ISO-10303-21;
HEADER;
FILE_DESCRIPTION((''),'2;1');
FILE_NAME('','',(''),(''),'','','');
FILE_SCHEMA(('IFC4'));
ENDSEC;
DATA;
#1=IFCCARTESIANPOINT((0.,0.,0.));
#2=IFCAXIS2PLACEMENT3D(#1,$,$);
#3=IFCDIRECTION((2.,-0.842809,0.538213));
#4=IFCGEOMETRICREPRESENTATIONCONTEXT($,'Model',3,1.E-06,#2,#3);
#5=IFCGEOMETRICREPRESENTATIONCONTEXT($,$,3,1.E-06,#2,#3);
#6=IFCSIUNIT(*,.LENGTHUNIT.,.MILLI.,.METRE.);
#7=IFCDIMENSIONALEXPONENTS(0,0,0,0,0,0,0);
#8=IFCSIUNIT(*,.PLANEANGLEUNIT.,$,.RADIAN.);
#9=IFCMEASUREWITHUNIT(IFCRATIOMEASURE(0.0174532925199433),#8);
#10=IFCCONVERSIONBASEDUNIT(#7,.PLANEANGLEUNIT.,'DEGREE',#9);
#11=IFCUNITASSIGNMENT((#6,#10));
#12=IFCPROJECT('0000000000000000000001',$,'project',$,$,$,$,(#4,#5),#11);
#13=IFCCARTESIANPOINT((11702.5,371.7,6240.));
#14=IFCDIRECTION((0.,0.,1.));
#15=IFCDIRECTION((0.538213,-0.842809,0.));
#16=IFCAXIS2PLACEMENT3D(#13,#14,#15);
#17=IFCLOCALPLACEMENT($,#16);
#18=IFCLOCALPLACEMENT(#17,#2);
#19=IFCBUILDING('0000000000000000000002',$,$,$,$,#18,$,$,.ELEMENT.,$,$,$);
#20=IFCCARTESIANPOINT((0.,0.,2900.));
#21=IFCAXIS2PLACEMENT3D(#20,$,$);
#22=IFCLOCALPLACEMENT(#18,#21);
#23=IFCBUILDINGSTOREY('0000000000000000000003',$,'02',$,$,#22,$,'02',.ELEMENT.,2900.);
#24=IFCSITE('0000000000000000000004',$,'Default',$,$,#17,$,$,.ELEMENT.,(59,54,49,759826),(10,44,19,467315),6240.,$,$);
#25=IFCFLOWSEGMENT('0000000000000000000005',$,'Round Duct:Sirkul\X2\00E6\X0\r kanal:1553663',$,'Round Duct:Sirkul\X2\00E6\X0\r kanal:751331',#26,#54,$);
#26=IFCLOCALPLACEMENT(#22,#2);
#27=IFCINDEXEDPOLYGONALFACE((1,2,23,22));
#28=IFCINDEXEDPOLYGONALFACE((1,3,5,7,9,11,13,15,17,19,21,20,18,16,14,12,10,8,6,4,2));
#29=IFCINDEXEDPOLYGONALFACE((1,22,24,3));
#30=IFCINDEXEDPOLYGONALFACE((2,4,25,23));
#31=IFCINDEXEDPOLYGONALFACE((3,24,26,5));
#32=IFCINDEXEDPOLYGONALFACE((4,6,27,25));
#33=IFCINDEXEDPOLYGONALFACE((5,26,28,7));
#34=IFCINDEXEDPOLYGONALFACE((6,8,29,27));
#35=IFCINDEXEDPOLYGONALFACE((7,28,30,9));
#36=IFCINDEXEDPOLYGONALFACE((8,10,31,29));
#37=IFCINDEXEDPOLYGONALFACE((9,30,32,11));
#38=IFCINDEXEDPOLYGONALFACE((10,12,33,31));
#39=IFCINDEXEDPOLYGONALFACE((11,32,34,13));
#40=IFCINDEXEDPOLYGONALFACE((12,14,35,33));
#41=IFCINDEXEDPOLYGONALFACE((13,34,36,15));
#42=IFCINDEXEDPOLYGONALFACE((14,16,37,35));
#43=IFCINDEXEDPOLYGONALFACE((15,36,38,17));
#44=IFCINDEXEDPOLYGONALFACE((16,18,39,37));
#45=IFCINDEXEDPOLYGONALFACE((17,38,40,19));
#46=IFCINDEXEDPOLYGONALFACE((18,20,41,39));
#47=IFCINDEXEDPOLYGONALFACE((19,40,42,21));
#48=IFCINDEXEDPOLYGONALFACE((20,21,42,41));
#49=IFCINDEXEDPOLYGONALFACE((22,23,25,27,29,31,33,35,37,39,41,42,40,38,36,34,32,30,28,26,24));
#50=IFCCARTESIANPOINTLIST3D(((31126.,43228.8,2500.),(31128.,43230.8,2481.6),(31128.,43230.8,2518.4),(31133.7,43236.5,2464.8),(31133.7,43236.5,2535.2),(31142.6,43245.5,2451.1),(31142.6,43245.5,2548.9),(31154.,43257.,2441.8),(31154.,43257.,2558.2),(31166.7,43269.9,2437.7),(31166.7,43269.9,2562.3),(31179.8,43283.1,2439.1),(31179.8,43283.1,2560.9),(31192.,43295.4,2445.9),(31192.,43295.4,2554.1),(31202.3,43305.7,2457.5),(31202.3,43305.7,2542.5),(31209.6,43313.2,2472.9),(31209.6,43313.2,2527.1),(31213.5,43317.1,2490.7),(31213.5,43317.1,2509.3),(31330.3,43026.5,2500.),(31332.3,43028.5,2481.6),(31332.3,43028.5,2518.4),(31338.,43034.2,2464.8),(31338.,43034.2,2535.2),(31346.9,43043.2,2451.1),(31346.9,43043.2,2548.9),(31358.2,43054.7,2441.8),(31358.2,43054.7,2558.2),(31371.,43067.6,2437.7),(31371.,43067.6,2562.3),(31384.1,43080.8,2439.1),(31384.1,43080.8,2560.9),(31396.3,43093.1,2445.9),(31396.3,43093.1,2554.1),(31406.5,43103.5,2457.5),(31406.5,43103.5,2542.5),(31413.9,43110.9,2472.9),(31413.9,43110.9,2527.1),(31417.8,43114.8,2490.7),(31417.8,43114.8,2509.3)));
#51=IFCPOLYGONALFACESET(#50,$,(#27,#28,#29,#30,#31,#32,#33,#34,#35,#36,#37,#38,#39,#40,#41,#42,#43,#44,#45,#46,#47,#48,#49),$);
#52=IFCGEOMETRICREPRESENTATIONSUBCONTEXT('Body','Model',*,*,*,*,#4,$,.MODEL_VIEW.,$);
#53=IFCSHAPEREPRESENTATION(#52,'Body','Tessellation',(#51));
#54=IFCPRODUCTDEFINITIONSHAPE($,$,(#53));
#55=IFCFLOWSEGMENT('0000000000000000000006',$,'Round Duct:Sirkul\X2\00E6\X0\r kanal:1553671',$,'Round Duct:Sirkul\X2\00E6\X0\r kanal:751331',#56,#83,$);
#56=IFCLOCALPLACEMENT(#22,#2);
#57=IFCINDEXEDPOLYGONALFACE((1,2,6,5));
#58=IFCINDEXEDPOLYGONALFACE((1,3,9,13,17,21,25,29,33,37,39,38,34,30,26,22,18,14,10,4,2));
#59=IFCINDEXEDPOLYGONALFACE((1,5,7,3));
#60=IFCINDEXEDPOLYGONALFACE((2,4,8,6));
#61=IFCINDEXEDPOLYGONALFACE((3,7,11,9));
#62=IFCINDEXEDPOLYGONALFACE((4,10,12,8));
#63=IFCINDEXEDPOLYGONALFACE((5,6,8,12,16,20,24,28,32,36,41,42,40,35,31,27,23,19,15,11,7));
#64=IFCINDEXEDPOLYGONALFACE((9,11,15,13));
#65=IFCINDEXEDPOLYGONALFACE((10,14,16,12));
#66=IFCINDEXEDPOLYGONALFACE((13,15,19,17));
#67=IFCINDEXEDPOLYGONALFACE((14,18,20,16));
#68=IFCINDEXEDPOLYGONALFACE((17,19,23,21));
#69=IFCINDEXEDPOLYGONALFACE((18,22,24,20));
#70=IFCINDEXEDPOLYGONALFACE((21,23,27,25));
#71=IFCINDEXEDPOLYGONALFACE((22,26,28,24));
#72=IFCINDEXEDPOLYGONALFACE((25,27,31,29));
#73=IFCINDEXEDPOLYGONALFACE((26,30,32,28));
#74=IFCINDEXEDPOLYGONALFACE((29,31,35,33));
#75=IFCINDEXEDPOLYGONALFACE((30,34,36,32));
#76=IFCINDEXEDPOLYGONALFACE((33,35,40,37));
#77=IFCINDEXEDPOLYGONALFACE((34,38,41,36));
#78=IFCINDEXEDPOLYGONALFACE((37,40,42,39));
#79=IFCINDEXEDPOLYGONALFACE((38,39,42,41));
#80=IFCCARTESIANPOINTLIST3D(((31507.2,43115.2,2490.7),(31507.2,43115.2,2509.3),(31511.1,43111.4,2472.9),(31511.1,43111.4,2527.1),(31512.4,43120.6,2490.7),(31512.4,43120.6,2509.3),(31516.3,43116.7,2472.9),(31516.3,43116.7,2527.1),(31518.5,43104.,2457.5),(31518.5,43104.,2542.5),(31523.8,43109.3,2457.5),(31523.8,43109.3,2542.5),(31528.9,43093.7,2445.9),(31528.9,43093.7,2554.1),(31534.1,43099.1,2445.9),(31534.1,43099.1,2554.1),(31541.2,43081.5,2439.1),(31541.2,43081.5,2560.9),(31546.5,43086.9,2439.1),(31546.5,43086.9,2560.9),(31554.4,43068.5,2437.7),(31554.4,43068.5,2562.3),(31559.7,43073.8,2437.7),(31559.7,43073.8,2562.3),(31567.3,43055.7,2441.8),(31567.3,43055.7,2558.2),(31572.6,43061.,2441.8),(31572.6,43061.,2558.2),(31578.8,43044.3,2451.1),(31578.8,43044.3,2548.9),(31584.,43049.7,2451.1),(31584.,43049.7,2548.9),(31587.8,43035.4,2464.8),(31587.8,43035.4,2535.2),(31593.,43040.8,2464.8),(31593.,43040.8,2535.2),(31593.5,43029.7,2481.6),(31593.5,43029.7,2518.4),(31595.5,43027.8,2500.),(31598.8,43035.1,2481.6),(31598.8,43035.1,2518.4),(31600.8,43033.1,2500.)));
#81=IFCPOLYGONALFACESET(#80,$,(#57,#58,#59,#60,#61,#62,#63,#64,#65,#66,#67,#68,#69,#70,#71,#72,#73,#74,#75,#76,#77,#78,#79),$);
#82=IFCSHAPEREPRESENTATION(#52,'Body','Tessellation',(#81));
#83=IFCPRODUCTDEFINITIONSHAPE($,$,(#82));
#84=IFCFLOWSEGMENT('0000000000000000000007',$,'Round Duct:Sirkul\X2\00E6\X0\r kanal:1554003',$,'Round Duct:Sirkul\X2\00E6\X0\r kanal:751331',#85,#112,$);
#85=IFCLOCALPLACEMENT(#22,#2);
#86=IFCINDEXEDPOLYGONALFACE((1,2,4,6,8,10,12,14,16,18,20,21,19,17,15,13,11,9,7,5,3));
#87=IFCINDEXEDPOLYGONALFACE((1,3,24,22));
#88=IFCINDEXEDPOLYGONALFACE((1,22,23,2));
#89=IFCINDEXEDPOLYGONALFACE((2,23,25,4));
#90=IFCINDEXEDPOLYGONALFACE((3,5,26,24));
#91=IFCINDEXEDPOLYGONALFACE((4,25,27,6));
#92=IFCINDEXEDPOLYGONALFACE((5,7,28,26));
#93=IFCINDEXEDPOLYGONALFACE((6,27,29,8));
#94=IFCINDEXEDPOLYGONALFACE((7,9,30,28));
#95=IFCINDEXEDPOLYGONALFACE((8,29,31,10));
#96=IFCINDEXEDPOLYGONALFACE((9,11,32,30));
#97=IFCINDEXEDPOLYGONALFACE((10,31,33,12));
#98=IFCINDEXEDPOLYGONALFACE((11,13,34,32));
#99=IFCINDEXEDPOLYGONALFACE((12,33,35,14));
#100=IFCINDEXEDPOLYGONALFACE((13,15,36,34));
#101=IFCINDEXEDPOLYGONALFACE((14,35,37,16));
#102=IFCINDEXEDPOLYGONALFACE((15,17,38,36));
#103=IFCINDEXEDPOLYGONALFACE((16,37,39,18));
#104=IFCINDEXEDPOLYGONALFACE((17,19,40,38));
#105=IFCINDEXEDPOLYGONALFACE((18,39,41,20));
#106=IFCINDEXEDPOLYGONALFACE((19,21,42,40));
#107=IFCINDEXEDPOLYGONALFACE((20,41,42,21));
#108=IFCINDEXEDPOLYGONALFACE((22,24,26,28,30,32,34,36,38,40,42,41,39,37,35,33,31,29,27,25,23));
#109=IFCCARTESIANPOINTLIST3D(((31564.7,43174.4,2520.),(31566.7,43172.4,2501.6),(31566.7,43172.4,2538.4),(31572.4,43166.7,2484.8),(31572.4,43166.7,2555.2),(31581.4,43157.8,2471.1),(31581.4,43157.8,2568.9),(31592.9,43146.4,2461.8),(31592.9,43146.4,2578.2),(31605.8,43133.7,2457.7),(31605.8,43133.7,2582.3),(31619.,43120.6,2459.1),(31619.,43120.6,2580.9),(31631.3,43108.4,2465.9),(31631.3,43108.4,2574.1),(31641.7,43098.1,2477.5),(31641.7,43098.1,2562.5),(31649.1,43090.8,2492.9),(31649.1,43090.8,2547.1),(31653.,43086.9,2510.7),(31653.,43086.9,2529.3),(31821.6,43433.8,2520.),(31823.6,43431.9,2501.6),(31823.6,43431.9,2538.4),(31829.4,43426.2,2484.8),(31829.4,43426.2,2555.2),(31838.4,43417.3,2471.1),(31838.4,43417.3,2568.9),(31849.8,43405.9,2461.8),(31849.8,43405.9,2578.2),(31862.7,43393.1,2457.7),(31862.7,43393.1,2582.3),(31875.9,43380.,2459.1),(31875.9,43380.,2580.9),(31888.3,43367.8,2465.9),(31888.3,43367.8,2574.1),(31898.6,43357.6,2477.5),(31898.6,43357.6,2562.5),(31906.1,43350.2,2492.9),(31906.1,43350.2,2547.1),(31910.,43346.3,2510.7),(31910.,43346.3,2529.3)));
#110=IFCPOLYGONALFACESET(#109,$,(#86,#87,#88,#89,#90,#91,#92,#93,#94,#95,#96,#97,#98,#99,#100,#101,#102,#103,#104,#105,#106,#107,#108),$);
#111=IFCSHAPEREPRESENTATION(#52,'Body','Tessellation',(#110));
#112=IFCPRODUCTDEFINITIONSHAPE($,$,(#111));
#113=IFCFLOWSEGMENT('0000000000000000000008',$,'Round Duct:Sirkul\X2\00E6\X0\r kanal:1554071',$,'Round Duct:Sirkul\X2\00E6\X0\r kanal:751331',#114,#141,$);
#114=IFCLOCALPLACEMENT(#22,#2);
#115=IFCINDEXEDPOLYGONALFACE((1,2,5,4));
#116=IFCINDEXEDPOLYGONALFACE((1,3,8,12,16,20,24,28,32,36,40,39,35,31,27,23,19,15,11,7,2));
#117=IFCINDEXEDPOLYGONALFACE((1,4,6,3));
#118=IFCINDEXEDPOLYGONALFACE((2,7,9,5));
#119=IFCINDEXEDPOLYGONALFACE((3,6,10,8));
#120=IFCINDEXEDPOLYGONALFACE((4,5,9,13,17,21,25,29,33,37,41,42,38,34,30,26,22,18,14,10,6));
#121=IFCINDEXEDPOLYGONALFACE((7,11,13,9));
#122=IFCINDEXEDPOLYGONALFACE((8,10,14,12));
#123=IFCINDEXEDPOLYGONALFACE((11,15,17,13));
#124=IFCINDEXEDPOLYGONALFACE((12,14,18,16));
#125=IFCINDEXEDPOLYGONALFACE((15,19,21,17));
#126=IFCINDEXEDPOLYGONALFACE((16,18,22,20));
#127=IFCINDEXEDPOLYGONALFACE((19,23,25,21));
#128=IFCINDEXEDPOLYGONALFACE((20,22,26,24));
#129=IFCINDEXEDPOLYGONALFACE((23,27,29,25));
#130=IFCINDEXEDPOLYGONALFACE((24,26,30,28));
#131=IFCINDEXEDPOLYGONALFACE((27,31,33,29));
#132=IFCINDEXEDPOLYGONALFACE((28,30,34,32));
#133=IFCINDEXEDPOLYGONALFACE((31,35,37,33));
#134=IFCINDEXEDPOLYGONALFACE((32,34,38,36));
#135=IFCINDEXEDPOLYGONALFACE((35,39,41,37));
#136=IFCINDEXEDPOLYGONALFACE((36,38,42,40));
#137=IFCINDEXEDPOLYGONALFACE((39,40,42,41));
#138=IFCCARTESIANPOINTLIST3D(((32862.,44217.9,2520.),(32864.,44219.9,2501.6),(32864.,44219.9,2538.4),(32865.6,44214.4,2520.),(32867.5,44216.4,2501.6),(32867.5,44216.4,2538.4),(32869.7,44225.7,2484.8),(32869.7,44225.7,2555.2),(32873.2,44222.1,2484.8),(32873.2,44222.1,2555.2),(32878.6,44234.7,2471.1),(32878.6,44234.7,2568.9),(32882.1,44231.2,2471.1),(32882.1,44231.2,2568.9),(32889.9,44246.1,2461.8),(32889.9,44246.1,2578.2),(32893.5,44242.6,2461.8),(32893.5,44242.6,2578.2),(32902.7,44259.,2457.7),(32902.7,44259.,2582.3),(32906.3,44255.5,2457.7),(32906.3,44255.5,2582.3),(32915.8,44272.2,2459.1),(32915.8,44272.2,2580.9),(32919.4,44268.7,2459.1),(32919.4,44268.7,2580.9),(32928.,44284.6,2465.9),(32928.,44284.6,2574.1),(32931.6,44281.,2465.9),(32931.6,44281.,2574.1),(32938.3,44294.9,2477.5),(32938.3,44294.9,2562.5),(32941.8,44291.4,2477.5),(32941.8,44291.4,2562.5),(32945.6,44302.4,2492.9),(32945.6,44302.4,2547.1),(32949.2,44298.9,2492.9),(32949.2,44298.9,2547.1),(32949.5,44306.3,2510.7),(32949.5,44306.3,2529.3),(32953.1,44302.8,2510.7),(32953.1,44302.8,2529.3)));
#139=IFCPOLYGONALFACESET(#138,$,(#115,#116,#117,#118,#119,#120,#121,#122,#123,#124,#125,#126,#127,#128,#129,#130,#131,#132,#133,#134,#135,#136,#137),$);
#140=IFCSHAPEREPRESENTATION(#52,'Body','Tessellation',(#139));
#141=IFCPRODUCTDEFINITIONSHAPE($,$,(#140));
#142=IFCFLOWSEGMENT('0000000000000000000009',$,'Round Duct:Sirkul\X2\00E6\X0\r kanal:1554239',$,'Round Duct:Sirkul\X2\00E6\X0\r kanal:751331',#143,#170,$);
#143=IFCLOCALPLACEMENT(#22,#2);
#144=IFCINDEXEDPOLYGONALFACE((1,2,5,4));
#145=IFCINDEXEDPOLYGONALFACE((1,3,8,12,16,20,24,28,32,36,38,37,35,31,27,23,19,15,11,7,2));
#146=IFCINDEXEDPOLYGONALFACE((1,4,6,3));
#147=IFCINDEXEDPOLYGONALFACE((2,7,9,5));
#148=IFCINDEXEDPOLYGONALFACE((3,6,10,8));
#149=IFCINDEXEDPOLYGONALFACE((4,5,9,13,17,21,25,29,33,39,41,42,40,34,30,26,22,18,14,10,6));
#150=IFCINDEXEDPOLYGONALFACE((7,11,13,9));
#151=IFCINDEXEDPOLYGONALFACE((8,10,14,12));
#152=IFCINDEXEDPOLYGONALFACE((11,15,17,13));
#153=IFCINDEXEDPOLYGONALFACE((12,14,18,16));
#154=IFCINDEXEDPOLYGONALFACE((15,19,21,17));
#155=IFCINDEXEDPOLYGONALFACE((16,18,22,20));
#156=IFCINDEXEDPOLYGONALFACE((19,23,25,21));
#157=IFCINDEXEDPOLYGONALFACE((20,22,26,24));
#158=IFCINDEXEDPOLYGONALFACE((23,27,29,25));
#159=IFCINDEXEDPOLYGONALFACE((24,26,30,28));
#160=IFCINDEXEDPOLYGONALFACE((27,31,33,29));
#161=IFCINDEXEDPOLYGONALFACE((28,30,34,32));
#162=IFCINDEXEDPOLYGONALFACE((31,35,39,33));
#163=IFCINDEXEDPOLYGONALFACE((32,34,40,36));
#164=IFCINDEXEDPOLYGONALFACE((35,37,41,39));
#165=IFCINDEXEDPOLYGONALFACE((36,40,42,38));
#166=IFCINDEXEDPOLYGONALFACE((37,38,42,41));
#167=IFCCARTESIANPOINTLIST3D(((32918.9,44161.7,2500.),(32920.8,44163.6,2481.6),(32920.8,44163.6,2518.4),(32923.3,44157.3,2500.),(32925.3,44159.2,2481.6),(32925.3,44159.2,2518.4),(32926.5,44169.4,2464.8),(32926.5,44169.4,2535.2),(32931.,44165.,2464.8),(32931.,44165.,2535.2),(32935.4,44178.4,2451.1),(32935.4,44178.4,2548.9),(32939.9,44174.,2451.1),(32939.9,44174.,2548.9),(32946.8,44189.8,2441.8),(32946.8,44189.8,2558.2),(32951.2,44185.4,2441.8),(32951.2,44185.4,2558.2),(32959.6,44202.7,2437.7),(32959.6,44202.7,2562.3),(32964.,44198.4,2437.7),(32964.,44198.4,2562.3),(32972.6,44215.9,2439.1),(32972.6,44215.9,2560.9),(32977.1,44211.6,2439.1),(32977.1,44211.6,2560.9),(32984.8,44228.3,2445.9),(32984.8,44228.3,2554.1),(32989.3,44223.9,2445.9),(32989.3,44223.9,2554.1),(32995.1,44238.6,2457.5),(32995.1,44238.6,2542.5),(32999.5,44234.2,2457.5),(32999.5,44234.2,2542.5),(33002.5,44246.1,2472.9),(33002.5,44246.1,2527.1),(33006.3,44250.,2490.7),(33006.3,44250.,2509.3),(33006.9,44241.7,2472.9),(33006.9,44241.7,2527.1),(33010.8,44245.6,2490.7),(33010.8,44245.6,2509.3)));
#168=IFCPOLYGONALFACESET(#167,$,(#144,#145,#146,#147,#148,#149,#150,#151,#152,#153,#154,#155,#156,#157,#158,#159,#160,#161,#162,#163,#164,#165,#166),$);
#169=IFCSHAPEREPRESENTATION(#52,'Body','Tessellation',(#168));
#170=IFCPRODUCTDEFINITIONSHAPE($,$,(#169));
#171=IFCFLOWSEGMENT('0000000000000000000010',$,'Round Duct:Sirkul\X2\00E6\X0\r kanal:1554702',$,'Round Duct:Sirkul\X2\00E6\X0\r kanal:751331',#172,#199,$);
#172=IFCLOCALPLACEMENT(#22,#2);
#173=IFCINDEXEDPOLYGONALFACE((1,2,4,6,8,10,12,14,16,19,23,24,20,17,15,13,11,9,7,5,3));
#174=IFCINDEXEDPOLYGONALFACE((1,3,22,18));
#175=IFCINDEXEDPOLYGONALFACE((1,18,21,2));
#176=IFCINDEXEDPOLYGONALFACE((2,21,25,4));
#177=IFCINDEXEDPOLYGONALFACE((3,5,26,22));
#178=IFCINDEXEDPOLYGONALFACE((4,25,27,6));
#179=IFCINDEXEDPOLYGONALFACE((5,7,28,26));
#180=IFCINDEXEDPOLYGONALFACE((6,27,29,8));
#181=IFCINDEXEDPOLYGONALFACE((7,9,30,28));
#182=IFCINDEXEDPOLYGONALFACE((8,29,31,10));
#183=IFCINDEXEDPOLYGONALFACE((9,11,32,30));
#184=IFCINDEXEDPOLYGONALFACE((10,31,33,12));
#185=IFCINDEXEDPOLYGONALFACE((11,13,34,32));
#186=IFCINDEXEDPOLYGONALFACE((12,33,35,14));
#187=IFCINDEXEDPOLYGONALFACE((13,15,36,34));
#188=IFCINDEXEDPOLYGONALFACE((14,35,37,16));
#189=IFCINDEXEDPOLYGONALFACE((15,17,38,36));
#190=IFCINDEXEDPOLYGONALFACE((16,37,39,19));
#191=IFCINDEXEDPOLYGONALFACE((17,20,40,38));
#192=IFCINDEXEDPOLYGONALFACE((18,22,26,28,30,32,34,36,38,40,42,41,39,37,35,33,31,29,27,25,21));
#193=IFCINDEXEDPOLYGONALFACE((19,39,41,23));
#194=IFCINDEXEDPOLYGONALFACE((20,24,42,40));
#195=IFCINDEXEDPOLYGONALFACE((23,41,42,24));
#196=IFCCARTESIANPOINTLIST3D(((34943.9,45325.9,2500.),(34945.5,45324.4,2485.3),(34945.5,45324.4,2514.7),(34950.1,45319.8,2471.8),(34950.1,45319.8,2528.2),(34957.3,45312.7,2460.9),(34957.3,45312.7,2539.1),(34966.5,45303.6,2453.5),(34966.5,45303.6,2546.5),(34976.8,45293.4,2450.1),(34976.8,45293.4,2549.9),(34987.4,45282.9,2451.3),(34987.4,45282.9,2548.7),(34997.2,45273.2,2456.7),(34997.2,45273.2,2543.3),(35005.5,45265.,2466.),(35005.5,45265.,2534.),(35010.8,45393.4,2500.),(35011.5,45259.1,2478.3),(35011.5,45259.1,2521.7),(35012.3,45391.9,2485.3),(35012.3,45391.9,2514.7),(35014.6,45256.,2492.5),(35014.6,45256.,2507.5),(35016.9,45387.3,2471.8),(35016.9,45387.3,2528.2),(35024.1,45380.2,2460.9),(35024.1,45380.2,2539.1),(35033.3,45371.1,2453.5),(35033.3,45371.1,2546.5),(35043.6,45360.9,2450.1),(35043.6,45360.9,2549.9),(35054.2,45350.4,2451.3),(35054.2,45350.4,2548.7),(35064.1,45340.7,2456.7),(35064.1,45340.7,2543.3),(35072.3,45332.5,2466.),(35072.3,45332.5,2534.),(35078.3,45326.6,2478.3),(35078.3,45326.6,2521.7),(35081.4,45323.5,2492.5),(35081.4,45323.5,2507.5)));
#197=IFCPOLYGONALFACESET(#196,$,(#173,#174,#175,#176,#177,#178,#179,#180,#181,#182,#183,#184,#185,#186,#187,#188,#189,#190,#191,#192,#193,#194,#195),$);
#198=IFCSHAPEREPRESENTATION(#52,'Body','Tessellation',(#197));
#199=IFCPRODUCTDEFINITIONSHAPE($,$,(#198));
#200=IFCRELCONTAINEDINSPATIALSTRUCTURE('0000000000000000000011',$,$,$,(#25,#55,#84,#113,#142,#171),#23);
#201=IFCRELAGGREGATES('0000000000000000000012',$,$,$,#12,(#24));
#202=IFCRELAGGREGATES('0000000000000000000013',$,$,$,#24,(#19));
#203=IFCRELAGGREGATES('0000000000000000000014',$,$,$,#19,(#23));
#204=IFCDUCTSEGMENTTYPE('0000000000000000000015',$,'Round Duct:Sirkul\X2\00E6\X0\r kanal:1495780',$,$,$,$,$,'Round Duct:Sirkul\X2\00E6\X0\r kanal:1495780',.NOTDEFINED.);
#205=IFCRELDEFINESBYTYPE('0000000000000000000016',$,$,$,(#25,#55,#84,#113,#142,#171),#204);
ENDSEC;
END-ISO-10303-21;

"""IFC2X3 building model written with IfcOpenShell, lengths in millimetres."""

from ifc_helpers import new_model, entity, si_unit, converted_unit, direction, frame, origin, origin_2d_with_axis, place, context, subcontext, project, spatial, circle, extrude, type_object, element, save


model = new_model("IFC2X3")

# Units and contexts
model_context = context("Model", 3, precision=1e-06, world=origin(), true_north=direction((2.0, -0.842809, 0.538213)))
context_of_model = context(None, 3, precision=1e-06, world=origin(), true_north=direction((2.0, -0.842809, 0.538213)))
body_context = subcontext(model_context, "Body", "Model", "MODEL_VIEW")
ifc_project = project(units=[si_unit("LENGTHUNIT", "METRE", prefix="MILLI"), converted_unit("PLANEANGLEUNIT", "DEGREE", entity("IfcRatioMeasure", 0.0174532925199433), si_unit("PLANEANGLEUNIT", "RADIAN"), dimensions=[0, 0, 0, 0, 0, 0, 0])], contexts=[model_context, context_of_model])

# Site, building, storey
site_placement = place(None, frame((11702.5, 371.7, 6240.0), z_axis=(0.0, 0.0, 1.0), x_axis=(0.538213, -0.842809, 0.0)))
site = spatial("IfcSite", under=ifc_project, at=site_placement, Name="Default", CompositionType="ELEMENT", RefLatitude=(59, 54, 49, 759826), RefLongitude=(10, 44, 19, 467315), RefElevation=6240.0)
building_placement = place(site_placement, origin())
building = spatial("IfcBuilding", under=site, at=building_placement, CompositionType="ELEMENT")
storey_placement = place(building_placement, frame((0.0, 0.0, 2900.0)))
storey = spatial("IfcBuildingStorey", under=building, at=storey_placement, Name="02", LongName="02", CompositionType="ELEMENT", Elevation=2900.0)

# Flow segments
duct_segment_type = type_object("IfcDuctSegmentType", Name="Round Duct:Sirkulær kanal:1495780", ElementType="Round Duct:Sirkulær kanal:1495780", PredefinedType="NOTDEFINED")
flow_segment_1_placement = place(storey_placement, origin())
element("IfcFlowSegment", 1, at=flow_segment_1_placement, inside=storey, type_object=duct_segment_type, Name="Round Duct:Sirkulær kanal:1553663", ObjectType="Round Duct:Sirkulær kanal:751331", context=body_context, shape_type="SweptSolid", body=[
    extrude(circle(Radius=62.5, at=origin_2d_with_axis()), frame((31374.3, 43070.9, 2500.0), z_axis=(-0.710554, 0.703643, 0.0), x_axis=(-0.703643, -0.710554, 0.0)), (0.0, 0.0, 1.0), 287.5),
])
flow_segment_2_placement = place(storey_placement, origin())
element("IfcFlowSegment", 2, at=flow_segment_2_placement, inside=storey, type_object=duct_segment_type, Name="Round Duct:Sirkulær kanal:1553671", ObjectType="Round Duct:Sirkulær kanal:751331", context=body_context, shape_type="SweptSolid", body=[
    extrude(circle(Radius=62.5, at=origin_2d_with_axis()), frame((31551.1, 43071.8, 2500.0), z_axis=(0.703643, 0.710554, 0.0), x_axis=(0.710554, -0.703643, 0.0)), (0.0, 0.0, 1.0), 7.5),
])
flow_segment_3_placement = place(storey_placement, origin())
element("IfcFlowSegment", 3, at=flow_segment_3_placement, inside=storey, type_object=duct_segment_type, Name="Round Duct:Sirkulær kanal:1554003", ObjectType="Round Duct:Sirkulær kanal:751331", context=body_context, shape_type="SweptSolid", body=[
    extrude(circle(Radius=62.5, at=origin_2d_with_axis()), frame((31609.1, 43130.4, 2520.0), z_axis=(0.703643, 0.710554, 0.0), x_axis=(-0.710554, 0.703643, 0.0)), (0.0, 0.0, 1.0), 365.1),
])
flow_segment_4_placement = place(storey_placement, origin())
element("IfcFlowSegment", 4, at=flow_segment_4_placement, inside=storey, type_object=duct_segment_type, Name="Round Duct:Sirkulær kanal:1554071", ObjectType="Round Duct:Sirkulær kanal:751331", context=body_context, shape_type="SweptSolid", body=[
    extrude(circle(Radius=62.5, at=origin_2d_with_axis()), frame((32906.0, 44262.4, 2520.0), z_axis=(0.710554, -0.703643, 0.0), x_axis=(-0.703643, -0.710554, 0.0)), (0.0, 0.0, 1.0), 5.0),
])
flow_segment_5_placement = place(storey_placement, origin())
element("IfcFlowSegment", 5, at=flow_segment_5_placement, inside=storey, type_object=duct_segment_type, Name="Round Duct:Sirkulær kanal:1554239", ObjectType="Round Duct:Sirkulær kanal:751331", context=body_context, shape_type="SweptSolid", body=[
    extrude(circle(Radius=62.5, at=origin_2d_with_axis()), frame((32967.3, 44201.7, 2500.0), z_axis=(-0.710554, 0.703643, 0.0), x_axis=(-0.703643, -0.710554, 0.0)), (0.0, 0.0, 1.0), 6.2),
])
flow_segment_6_placement = place(storey_placement, origin())
element("IfcFlowSegment", 6, at=flow_segment_6_placement, inside=storey, type_object=duct_segment_type, Name="Round Duct:Sirkulær kanal:1554702", ObjectType="Round Duct:Sirkulær kanal:751331", context=body_context, shape_type="SweptSolid", body=[
    extrude(circle(Radius=50.0, at=origin_2d_with_axis()), frame((34979.4, 45290.8, 2500.0), z_axis=(0.703643, 0.710554, 0.0), x_axis=(-0.710554, 0.703643, 0.0)), (0.0, 0.0, 1.0), 95.0),
])

save(model, "model.ifc")
